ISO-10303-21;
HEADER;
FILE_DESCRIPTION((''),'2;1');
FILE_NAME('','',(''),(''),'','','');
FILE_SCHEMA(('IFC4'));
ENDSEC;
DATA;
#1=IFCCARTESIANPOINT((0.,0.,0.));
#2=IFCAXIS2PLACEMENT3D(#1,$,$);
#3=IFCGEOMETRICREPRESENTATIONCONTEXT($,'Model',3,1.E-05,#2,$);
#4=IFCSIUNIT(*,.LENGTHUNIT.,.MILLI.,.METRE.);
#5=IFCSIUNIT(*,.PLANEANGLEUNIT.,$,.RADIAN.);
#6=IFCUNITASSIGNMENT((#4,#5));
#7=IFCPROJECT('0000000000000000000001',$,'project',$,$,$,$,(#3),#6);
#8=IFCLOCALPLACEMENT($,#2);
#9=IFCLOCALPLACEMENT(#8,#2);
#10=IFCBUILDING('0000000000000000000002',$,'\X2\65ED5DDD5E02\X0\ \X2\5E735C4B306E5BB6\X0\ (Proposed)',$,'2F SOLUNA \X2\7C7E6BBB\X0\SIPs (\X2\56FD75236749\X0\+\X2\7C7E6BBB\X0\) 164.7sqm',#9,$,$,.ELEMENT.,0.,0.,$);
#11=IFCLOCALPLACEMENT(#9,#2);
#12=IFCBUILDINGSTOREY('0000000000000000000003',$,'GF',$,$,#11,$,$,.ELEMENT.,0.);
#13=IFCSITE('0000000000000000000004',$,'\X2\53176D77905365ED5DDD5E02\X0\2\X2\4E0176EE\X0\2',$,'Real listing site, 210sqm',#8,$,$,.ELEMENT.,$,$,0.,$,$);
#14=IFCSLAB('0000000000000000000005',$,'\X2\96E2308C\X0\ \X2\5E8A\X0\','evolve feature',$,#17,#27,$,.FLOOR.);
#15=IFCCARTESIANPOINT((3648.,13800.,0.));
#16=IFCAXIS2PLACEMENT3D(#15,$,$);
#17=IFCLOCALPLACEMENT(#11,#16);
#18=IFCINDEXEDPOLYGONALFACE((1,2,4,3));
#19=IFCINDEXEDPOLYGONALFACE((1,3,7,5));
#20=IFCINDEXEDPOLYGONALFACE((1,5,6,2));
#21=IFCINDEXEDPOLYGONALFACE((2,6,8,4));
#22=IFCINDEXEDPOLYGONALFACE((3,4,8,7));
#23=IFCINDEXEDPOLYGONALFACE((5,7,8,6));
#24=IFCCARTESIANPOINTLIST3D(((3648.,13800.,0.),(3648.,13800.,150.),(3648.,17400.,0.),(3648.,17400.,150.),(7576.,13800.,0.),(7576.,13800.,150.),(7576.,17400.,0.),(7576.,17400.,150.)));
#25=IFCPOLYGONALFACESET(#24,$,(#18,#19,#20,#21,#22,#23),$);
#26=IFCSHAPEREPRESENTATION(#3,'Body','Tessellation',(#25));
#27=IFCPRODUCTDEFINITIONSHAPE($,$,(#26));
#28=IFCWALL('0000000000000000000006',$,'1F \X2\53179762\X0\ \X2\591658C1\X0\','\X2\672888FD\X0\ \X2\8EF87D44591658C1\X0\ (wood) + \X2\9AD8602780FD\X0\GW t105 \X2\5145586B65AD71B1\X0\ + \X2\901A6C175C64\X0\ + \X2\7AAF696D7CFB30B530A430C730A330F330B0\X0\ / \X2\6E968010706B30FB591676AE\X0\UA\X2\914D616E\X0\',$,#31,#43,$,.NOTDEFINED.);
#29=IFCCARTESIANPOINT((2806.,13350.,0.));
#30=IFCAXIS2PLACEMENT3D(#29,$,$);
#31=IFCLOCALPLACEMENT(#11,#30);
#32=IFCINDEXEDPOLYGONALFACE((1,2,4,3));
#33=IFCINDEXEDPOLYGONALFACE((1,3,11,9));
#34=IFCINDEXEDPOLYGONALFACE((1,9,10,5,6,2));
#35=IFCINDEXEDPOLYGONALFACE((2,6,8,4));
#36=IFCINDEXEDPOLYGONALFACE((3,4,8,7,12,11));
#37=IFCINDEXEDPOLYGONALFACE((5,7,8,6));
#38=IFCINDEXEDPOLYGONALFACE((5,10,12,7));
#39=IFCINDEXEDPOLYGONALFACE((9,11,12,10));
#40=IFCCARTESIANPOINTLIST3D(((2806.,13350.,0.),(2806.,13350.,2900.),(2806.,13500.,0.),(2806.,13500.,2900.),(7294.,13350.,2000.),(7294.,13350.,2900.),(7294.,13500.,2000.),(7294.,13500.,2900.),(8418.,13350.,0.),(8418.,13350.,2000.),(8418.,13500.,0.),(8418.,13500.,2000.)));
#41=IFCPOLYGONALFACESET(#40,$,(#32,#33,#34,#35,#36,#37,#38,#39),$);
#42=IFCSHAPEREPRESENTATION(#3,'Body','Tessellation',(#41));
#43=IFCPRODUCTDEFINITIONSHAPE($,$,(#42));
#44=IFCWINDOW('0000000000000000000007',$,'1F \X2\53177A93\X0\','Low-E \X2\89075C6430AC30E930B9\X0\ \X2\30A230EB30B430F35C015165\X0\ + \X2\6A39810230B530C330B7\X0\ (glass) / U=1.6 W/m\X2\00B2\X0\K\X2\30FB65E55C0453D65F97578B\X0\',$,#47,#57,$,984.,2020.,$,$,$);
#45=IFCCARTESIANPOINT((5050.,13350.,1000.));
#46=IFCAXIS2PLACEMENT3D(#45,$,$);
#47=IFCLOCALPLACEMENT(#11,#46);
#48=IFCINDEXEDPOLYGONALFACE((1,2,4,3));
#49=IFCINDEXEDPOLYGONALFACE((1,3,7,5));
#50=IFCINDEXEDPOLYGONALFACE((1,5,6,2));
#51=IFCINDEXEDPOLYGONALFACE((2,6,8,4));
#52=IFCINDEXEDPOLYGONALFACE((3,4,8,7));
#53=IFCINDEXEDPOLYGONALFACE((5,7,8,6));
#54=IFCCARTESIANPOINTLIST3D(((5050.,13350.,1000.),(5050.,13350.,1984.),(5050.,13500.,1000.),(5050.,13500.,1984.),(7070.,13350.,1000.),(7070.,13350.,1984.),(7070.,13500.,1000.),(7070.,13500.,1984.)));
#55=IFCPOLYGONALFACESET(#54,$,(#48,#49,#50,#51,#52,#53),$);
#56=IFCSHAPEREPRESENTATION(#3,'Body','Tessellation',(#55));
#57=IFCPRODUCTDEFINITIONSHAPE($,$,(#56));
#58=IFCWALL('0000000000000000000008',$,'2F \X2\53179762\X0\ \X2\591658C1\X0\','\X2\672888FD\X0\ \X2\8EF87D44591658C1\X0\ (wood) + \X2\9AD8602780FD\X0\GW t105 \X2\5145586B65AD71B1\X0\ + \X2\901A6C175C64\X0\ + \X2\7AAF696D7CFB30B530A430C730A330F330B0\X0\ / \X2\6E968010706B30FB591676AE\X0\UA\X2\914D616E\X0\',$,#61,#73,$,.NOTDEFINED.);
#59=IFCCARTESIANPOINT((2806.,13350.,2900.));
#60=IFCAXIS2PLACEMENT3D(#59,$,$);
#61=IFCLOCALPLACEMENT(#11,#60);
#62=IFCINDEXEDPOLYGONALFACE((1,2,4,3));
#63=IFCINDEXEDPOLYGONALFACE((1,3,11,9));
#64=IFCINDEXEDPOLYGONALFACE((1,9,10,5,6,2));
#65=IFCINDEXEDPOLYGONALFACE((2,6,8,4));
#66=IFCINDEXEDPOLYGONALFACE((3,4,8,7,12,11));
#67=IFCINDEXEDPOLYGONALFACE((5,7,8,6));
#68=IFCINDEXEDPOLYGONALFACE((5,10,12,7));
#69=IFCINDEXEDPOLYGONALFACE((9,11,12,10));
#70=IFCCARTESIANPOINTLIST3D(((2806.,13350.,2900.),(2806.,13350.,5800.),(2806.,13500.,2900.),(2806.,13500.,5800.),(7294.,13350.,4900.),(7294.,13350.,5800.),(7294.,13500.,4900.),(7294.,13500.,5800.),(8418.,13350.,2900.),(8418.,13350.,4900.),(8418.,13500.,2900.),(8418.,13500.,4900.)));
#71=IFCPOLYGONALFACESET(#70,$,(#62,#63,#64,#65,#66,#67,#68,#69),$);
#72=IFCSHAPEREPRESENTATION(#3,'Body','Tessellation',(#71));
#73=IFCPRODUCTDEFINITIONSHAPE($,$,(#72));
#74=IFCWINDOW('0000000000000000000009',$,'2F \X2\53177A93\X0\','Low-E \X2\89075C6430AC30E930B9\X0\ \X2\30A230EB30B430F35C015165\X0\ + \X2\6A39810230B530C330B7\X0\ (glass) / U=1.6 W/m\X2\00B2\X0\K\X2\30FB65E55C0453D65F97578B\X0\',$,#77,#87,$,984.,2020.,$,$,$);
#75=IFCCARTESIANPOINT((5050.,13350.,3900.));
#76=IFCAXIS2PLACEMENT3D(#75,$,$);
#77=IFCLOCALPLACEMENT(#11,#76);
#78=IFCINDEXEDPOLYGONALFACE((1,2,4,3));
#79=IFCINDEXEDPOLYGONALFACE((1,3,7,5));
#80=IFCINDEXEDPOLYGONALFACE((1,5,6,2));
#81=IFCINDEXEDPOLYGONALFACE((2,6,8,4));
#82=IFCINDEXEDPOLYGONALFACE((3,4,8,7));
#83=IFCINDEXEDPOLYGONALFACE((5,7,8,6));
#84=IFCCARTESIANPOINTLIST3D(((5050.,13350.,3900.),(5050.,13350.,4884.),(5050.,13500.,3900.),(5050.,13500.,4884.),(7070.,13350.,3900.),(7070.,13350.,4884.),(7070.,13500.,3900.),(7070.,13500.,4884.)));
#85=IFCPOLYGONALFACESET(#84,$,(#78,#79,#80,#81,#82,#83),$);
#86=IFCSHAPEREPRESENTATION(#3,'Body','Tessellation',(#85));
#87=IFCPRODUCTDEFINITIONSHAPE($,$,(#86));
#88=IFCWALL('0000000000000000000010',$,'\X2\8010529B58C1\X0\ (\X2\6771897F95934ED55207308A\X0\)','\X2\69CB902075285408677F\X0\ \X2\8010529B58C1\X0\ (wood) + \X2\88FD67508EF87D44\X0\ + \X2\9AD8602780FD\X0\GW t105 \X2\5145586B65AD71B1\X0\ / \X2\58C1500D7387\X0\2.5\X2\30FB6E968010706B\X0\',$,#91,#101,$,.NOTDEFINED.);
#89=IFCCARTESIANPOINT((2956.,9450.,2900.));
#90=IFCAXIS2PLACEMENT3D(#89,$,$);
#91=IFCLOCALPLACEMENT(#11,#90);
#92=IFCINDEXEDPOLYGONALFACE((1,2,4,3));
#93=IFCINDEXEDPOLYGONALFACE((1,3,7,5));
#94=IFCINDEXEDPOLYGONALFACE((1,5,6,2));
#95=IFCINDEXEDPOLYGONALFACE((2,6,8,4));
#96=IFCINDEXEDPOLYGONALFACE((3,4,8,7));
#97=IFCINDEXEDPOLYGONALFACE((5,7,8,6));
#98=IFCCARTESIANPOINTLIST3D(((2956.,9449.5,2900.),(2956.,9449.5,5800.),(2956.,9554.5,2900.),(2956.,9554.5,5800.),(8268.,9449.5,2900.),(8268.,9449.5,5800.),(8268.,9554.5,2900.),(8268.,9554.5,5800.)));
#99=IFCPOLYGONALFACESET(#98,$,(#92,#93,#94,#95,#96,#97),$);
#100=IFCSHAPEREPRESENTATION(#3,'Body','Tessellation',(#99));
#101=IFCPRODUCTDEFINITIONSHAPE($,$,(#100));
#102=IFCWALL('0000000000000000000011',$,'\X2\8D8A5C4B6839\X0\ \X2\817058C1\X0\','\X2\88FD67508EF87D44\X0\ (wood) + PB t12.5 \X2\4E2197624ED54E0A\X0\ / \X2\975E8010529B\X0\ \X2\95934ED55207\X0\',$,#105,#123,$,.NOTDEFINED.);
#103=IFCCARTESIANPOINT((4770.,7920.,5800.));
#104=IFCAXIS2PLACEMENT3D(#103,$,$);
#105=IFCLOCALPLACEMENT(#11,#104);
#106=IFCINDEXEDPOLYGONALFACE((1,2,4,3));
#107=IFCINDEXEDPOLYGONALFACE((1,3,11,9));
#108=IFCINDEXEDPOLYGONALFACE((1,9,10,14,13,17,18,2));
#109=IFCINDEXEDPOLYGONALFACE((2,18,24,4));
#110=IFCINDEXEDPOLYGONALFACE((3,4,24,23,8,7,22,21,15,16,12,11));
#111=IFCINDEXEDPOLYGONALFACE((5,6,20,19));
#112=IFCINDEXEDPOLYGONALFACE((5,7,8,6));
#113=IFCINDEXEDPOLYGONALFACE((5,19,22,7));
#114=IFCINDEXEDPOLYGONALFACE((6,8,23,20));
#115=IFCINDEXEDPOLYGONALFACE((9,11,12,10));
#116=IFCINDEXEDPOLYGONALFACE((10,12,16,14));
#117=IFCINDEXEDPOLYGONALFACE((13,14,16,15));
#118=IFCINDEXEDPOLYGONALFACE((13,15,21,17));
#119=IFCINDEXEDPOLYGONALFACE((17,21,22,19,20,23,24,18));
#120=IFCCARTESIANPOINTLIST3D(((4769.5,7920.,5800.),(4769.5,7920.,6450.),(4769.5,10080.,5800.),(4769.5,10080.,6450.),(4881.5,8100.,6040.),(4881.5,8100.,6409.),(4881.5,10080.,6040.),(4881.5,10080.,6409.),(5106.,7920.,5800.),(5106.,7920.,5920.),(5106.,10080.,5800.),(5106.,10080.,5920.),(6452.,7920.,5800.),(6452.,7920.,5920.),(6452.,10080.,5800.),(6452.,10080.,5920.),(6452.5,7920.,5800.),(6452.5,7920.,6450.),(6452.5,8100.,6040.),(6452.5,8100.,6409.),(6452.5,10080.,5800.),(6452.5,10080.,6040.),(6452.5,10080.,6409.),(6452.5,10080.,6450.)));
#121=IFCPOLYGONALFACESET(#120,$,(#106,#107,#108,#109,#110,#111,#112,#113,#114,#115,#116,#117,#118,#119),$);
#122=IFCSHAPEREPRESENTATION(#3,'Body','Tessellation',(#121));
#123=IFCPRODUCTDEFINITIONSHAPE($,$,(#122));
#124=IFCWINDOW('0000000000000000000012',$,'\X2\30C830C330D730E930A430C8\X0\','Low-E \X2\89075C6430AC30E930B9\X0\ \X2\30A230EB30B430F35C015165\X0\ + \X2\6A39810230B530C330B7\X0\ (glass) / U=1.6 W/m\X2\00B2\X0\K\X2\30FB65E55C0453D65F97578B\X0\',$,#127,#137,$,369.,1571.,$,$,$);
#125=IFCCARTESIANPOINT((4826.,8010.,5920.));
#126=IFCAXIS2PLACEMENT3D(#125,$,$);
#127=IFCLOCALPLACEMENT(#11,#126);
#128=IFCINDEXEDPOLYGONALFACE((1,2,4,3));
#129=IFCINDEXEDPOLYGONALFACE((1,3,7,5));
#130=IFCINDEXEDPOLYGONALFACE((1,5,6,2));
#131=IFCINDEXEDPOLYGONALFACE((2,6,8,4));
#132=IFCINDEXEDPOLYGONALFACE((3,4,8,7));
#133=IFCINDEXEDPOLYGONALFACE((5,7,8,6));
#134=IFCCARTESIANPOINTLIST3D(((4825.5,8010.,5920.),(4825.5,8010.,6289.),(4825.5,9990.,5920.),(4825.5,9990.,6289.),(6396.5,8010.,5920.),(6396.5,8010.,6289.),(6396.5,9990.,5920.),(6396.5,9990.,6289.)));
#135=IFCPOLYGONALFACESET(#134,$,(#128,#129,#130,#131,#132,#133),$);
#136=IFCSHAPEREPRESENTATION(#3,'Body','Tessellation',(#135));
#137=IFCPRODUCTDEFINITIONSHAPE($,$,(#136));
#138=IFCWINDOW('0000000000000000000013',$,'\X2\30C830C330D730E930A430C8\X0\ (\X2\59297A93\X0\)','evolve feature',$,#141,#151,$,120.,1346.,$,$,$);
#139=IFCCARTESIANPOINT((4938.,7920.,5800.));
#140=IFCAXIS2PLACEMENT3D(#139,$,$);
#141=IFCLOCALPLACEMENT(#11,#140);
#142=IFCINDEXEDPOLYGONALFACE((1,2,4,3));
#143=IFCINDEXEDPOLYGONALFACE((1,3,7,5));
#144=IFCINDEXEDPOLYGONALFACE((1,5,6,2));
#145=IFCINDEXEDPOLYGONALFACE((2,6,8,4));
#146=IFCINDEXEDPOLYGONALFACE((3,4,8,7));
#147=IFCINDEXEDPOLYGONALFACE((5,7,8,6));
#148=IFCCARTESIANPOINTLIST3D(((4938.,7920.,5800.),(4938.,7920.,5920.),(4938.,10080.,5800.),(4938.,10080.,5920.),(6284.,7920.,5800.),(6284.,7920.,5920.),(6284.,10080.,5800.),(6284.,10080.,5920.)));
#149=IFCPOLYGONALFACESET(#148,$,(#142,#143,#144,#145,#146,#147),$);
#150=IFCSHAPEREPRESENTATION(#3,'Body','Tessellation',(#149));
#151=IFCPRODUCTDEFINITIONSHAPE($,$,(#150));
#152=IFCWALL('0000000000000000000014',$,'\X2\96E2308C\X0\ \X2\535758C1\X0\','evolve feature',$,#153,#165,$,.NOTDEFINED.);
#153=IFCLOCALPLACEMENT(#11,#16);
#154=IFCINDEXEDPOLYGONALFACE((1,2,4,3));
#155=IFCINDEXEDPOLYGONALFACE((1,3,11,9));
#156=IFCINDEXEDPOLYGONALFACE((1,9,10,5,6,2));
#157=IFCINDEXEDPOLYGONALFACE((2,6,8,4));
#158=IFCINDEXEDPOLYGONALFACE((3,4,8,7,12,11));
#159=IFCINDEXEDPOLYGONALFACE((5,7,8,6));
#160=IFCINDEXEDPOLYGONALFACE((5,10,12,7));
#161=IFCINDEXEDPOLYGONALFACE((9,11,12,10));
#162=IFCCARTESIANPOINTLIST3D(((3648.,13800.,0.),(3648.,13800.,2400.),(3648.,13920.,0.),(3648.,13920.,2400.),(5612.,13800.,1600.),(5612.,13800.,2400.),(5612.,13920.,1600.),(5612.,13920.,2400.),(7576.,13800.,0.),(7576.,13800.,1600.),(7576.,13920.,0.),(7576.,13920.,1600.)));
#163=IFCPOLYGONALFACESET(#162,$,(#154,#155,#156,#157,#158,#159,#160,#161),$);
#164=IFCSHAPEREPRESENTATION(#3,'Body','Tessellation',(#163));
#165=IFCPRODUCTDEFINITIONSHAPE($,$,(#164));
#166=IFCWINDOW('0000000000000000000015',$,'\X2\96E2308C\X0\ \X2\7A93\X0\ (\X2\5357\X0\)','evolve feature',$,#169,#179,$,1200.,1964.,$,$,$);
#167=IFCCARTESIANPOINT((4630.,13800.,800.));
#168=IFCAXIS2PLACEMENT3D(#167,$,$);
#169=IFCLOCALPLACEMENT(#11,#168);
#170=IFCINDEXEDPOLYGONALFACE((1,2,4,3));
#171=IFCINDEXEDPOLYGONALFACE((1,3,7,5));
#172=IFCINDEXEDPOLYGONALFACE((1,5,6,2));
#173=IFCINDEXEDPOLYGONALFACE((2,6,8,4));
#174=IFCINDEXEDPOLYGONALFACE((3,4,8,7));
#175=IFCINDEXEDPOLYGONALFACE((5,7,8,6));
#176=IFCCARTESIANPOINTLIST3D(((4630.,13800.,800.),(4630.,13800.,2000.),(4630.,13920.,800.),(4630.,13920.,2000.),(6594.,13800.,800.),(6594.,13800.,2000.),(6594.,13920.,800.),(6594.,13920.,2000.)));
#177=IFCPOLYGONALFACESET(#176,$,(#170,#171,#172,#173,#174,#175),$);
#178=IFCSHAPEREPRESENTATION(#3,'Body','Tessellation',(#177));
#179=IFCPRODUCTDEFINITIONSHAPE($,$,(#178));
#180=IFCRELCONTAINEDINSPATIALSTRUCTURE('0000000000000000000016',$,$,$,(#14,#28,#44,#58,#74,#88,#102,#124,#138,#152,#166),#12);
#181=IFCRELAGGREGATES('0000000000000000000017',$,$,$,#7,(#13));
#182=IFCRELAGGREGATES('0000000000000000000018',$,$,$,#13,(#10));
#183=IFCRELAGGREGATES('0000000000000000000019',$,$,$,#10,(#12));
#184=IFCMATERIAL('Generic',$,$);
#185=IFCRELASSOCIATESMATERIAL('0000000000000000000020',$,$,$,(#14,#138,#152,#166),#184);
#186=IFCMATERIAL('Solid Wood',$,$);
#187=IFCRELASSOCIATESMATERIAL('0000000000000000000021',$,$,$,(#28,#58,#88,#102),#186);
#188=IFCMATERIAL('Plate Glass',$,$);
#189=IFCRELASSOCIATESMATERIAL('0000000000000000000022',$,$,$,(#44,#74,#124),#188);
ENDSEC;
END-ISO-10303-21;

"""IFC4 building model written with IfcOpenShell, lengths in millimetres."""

from ifc_helpers import new_model, si_unit, frame, frame_2d, origin, place, context, project, spatial, rectangle, extrude, material, element, fill, save


model = new_model("IFC4")

# Units and contexts
model_context = context("Model", 3, precision=1e-05, world=origin())
ifc_project = project(units=[si_unit("LENGTHUNIT", "METRE", prefix="MILLI"), si_unit("PLANEANGLEUNIT", "RADIAN")], contexts=[model_context])

# Site, building, storey
site_placement = place(None, origin())
site = spatial("IfcSite", under=ifc_project, at=site_placement, Name="北海道旭川市2丁目2", ObjectType="Real listing site, 210sqm", CompositionType="ELEMENT", RefElevation=0.0)
building_placement = place(site_placement, origin())
building = spatial("IfcBuilding", under=site, at=building_placement, Name="旭川市 平屋の家 (Proposed)", ObjectType="2F SOLUNA 籾殻SIPs (国産杉+籾殻) 164.7sqm", CompositionType="ELEMENT", ElevationOfRefHeight=0.0, ElevationOfTerrain=0.0)
storey_placement = place(building_placement, origin())
storey = spatial("IfcBuildingStorey", under=building, at=storey_placement, Name="GF", CompositionType="ELEMENT", Elevation=0.0)

# Slab
ifc_material_1 = material(Name="Generic")
slab_placement = place(storey_placement, frame((3648.0, 13800.0, 0.0)))
element("IfcSlab", 1, at=slab_placement, inside=storey, material=ifc_material_1, Name="離れ 床", Description="evolve feature", PredefinedType="FLOOR", context=model_context, shape_type="SweptSolid", body=[
    extrude(rectangle(XDim=3928.0, YDim=3600.0, at=frame_2d((1964.0, 1800.0))), frame((3648.0, 13800.0, 0.0)), (0.0, 0.0, 1.0), 150.0),
])

# Wall, opening, window
ifc_material_2 = material(Name="Solid Wood")
wall_1_placement = place(storey_placement, frame((2806.0, 13350.0, 0.0)))
wall_1 = element("IfcWall", 2, at=wall_1_placement, inside=storey, material=ifc_material_2, Name="1F 北面 外壁", Description="木製 軸組外壁 (wood) + 高性能GW t105 充填断熱 + 通気層 + 窯業系サイディング / 準耐火・外皮UA配慮", PredefinedType="NOTDEFINED", context=model_context, shape_type="SweptSolid", body=[
    extrude(rectangle(XDim=5612.0, YDim=150.0, at=frame_2d((2806.0, 75.0))), frame((2806.0, 13350.0, 0.0)), (0.0, 0.0, 1.0), 2900.0),
])
opening_1_placement = place(storey_placement, frame((5050.0, 13350.0, 1000.0)))
opening_1 = element("IfcOpeningElement", 3, at=opening_1_placement, cuts=wall_1, PredefinedType="NOTDEFINED", context=model_context, shape_type="SweptSolid", body=[
    extrude(rectangle(XDim=2020.0, YDim=150.0, at=frame_2d((1010.0, 75.0))), frame((5050.0, 13350.0, 1000.0)), (0.0, 0.0, 1.0), 984.0),
])
ifc_material_3 = material(Name="Plate Glass")
window_1_placement = place(storey_placement, frame((5050.0, 13350.0, 1000.0)))
window_1 = element("IfcWindow", 4, at=window_1_placement, inside=storey, material=ifc_material_3, Name="1F 北窓", Description="Low-E 複層ガラス アルゴン封入 + 樹脂サッシ (glass) / U=1.6 W/m²K・日射取得型", OverallHeight=984.0, OverallWidth=2020.0, context=model_context, shape_type="SweptSolid", body=[
    extrude(rectangle(XDim=2020.0, YDim=150.0, at=frame_2d((1010.0, 75.0))), frame((5050.0, 13350.0, 1000.0)), (0.0, 0.0, 1.0), 984.0),
])
fill(opening_1, window_1)

# Wall, opening, window
wall_2_placement = place(storey_placement, frame((2806.0, 13350.0, 2900.0)))
wall_2 = element("IfcWall", 5, at=wall_2_placement, inside=storey, material=ifc_material_2, Name="2F 北面 外壁", Description="木製 軸組外壁 (wood) + 高性能GW t105 充填断熱 + 通気層 + 窯業系サイディング / 準耐火・外皮UA配慮", PredefinedType="NOTDEFINED", context=model_context, shape_type="SweptSolid", body=[
    extrude(rectangle(XDim=5612.0, YDim=150.0, at=frame_2d((2806.0, 75.0))), frame((2806.0, 13350.0, 2900.0)), (0.0, 0.0, 1.0), 2900.0),
])
opening_2_placement = place(storey_placement, frame((5050.0, 13350.0, 3900.0)))
opening_2 = element("IfcOpeningElement", 6, at=opening_2_placement, cuts=wall_2, PredefinedType="NOTDEFINED", context=model_context, shape_type="SweptSolid", body=[
    extrude(rectangle(XDim=2020.0, YDim=150.0, at=frame_2d((1010.0, 75.0))), frame((5050.0, 13350.0, 3900.0)), (0.0, 0.0, 1.0), 984.0),
])
window_2_placement = place(storey_placement, frame((5050.0, 13350.0, 3900.0)))
window_2 = element("IfcWindow", 7, at=window_2_placement, inside=storey, material=ifc_material_3, Name="2F 北窓", Description="Low-E 複層ガラス アルゴン封入 + 樹脂サッシ (glass) / U=1.6 W/m²K・日射取得型", OverallHeight=984.0, OverallWidth=2020.0, context=model_context, shape_type="SweptSolid", body=[
    extrude(rectangle(XDim=2020.0, YDim=150.0, at=frame_2d((1010.0, 75.0))), frame((5050.0, 13350.0, 3900.0)), (0.0, 0.0, 1.0), 984.0),
])
fill(opening_2, window_2)

# Wall
wall_3_placement = place(storey_placement, frame((2956.0, 9450.0, 2900.0)))
element("IfcWall", 8, at=wall_3_placement, inside=storey, material=ifc_material_2, Name="耐力壁 (東西間仕切り)", Description="構造用合板 耐力壁 (wood) + 製材軸組 + 高性能GW t105 充填断熱 / 壁倍率2.5・準耐火", PredefinedType="NOTDEFINED", context=model_context, shape_type="SweptSolid", body=[
    extrude(rectangle(XDim=5312.0, YDim=105.0, at=frame_2d((2656.0, 52.0))), frame((2956.0, 9450.0, 2900.0)), (0.0, 0.0, 1.0), 2900.0),
])

# Wall, openings, windows
wall_4_placement = place(storey_placement, frame((4770.0, 7920.0, 5800.0)))
wall_4 = element("IfcWall", 9, at=wall_4_placement, inside=storey, material=ifc_material_2, Name="越屋根 腰壁", Description="製材軸組 (wood) + PB t12.5 両面仕上 / 非耐力 間仕切", PredefinedType="NOTDEFINED", context=model_context, shape_type="SweptSolid", body=[
    extrude(rectangle(XDim=1683.0, YDim=2160.0, at=frame_2d((841.0, 1080.0))), frame((4770.0, 7920.0, 5800.0)), (0.0, 0.0, 1.0), 650.0),
])
opening_3_placement = place(storey_placement, frame((4826.0, 8010.0, 5920.0)))
opening_3 = element("IfcOpeningElement", 10, at=opening_3_placement, cuts=wall_4, PredefinedType="NOTDEFINED", context=model_context, shape_type="SweptSolid", body=[
    extrude(rectangle(XDim=1571.0, YDim=1980.0, at=frame_2d((785.0, 990.0))), frame((4826.0, 8010.0, 5920.0)), (0.0, 0.0, 1.0), 369.0),
])
opening_4_placement = place(storey_placement, frame((4938.0, 7920.0, 5800.0)))
opening_4 = element("IfcOpeningElement", 11, at=opening_4_placement, cuts=wall_4, PredefinedType="NOTDEFINED", context=model_context, shape_type="SweptSolid", body=[
    extrude(rectangle(XDim=1346.0, YDim=2160.0, at=frame_2d((673.0, 1080.0))), frame((4938.0, 7920.0, 5800.0)), (0.0, 0.0, 1.0), 120.0),
])
window_3_placement = place(storey_placement, frame((4826.0, 8010.0, 5920.0)))
window_3 = element("IfcWindow", 12, at=window_3_placement, inside=storey, material=ifc_material_3, Name="トップライト", Description="Low-E 複層ガラス アルゴン封入 + 樹脂サッシ (glass) / U=1.6 W/m²K・日射取得型", OverallHeight=369.0, OverallWidth=1571.0, context=model_context, shape_type="SweptSolid", body=[
    extrude(rectangle(XDim=1571.0, YDim=1980.0, at=frame_2d((785.0, 990.0))), frame((4826.0, 8010.0, 5920.0)), (0.0, 0.0, 1.0), 369.0),
])
fill(opening_3, window_3)
window_4_placement = place(storey_placement, frame((4938.0, 7920.0, 5800.0)))
window_4 = element("IfcWindow", 13, at=window_4_placement, inside=storey, material=ifc_material_1, Name="トップライト (天窓)", Description="evolve feature", OverallHeight=120.0, OverallWidth=1346.0, context=model_context, shape_type="SweptSolid", body=[
    extrude(rectangle(XDim=1346.0, YDim=2160.0, at=frame_2d((673.0, 1080.0))), frame((4938.0, 7920.0, 5800.0)), (0.0, 0.0, 1.0), 120.0),
])
fill(opening_4, window_4)

# Wall, opening, window
wall_5_placement = place(storey_placement, frame((3648.0, 13800.0, 0.0)))
wall_5 = element("IfcWall", 14, at=wall_5_placement, inside=storey, material=ifc_material_1, Name="離れ 南壁", Description="evolve feature", PredefinedType="NOTDEFINED", context=model_context, shape_type="SweptSolid", body=[
    extrude(rectangle(XDim=3928.0, YDim=120.0, at=frame_2d((1964.0, 60.0))), frame((3648.0, 13800.0, 0.0)), (0.0, 0.0, 1.0), 2400.0),
])
opening_5_placement = place(storey_placement, frame((4630.0, 13800.0, 800.0)))
opening_5 = element("IfcOpeningElement", 15, at=opening_5_placement, cuts=wall_5, PredefinedType="NOTDEFINED", context=model_context, shape_type="SweptSolid", body=[
    extrude(rectangle(XDim=1964.0, YDim=120.0, at=frame_2d((982.0, 60.0))), frame((4630.0, 13800.0, 800.0)), (0.0, 0.0, 1.0), 1200.0),
])
window_5_placement = place(storey_placement, frame((4630.0, 13800.0, 800.0)))
window_5 = element("IfcWindow", 16, at=window_5_placement, inside=storey, material=ifc_material_1, Name="離れ 窓 (南)", Description="evolve feature", OverallHeight=1200.0, OverallWidth=1964.0, context=model_context, shape_type="SweptSolid", body=[
    extrude(rectangle(XDim=1964.0, YDim=120.0, at=frame_2d((982.0, 60.0))), frame((4630.0, 13800.0, 800.0)), (0.0, 0.0, 1.0), 1200.0),
])
fill(opening_5, window_5)

save(model, "model.ifc")
